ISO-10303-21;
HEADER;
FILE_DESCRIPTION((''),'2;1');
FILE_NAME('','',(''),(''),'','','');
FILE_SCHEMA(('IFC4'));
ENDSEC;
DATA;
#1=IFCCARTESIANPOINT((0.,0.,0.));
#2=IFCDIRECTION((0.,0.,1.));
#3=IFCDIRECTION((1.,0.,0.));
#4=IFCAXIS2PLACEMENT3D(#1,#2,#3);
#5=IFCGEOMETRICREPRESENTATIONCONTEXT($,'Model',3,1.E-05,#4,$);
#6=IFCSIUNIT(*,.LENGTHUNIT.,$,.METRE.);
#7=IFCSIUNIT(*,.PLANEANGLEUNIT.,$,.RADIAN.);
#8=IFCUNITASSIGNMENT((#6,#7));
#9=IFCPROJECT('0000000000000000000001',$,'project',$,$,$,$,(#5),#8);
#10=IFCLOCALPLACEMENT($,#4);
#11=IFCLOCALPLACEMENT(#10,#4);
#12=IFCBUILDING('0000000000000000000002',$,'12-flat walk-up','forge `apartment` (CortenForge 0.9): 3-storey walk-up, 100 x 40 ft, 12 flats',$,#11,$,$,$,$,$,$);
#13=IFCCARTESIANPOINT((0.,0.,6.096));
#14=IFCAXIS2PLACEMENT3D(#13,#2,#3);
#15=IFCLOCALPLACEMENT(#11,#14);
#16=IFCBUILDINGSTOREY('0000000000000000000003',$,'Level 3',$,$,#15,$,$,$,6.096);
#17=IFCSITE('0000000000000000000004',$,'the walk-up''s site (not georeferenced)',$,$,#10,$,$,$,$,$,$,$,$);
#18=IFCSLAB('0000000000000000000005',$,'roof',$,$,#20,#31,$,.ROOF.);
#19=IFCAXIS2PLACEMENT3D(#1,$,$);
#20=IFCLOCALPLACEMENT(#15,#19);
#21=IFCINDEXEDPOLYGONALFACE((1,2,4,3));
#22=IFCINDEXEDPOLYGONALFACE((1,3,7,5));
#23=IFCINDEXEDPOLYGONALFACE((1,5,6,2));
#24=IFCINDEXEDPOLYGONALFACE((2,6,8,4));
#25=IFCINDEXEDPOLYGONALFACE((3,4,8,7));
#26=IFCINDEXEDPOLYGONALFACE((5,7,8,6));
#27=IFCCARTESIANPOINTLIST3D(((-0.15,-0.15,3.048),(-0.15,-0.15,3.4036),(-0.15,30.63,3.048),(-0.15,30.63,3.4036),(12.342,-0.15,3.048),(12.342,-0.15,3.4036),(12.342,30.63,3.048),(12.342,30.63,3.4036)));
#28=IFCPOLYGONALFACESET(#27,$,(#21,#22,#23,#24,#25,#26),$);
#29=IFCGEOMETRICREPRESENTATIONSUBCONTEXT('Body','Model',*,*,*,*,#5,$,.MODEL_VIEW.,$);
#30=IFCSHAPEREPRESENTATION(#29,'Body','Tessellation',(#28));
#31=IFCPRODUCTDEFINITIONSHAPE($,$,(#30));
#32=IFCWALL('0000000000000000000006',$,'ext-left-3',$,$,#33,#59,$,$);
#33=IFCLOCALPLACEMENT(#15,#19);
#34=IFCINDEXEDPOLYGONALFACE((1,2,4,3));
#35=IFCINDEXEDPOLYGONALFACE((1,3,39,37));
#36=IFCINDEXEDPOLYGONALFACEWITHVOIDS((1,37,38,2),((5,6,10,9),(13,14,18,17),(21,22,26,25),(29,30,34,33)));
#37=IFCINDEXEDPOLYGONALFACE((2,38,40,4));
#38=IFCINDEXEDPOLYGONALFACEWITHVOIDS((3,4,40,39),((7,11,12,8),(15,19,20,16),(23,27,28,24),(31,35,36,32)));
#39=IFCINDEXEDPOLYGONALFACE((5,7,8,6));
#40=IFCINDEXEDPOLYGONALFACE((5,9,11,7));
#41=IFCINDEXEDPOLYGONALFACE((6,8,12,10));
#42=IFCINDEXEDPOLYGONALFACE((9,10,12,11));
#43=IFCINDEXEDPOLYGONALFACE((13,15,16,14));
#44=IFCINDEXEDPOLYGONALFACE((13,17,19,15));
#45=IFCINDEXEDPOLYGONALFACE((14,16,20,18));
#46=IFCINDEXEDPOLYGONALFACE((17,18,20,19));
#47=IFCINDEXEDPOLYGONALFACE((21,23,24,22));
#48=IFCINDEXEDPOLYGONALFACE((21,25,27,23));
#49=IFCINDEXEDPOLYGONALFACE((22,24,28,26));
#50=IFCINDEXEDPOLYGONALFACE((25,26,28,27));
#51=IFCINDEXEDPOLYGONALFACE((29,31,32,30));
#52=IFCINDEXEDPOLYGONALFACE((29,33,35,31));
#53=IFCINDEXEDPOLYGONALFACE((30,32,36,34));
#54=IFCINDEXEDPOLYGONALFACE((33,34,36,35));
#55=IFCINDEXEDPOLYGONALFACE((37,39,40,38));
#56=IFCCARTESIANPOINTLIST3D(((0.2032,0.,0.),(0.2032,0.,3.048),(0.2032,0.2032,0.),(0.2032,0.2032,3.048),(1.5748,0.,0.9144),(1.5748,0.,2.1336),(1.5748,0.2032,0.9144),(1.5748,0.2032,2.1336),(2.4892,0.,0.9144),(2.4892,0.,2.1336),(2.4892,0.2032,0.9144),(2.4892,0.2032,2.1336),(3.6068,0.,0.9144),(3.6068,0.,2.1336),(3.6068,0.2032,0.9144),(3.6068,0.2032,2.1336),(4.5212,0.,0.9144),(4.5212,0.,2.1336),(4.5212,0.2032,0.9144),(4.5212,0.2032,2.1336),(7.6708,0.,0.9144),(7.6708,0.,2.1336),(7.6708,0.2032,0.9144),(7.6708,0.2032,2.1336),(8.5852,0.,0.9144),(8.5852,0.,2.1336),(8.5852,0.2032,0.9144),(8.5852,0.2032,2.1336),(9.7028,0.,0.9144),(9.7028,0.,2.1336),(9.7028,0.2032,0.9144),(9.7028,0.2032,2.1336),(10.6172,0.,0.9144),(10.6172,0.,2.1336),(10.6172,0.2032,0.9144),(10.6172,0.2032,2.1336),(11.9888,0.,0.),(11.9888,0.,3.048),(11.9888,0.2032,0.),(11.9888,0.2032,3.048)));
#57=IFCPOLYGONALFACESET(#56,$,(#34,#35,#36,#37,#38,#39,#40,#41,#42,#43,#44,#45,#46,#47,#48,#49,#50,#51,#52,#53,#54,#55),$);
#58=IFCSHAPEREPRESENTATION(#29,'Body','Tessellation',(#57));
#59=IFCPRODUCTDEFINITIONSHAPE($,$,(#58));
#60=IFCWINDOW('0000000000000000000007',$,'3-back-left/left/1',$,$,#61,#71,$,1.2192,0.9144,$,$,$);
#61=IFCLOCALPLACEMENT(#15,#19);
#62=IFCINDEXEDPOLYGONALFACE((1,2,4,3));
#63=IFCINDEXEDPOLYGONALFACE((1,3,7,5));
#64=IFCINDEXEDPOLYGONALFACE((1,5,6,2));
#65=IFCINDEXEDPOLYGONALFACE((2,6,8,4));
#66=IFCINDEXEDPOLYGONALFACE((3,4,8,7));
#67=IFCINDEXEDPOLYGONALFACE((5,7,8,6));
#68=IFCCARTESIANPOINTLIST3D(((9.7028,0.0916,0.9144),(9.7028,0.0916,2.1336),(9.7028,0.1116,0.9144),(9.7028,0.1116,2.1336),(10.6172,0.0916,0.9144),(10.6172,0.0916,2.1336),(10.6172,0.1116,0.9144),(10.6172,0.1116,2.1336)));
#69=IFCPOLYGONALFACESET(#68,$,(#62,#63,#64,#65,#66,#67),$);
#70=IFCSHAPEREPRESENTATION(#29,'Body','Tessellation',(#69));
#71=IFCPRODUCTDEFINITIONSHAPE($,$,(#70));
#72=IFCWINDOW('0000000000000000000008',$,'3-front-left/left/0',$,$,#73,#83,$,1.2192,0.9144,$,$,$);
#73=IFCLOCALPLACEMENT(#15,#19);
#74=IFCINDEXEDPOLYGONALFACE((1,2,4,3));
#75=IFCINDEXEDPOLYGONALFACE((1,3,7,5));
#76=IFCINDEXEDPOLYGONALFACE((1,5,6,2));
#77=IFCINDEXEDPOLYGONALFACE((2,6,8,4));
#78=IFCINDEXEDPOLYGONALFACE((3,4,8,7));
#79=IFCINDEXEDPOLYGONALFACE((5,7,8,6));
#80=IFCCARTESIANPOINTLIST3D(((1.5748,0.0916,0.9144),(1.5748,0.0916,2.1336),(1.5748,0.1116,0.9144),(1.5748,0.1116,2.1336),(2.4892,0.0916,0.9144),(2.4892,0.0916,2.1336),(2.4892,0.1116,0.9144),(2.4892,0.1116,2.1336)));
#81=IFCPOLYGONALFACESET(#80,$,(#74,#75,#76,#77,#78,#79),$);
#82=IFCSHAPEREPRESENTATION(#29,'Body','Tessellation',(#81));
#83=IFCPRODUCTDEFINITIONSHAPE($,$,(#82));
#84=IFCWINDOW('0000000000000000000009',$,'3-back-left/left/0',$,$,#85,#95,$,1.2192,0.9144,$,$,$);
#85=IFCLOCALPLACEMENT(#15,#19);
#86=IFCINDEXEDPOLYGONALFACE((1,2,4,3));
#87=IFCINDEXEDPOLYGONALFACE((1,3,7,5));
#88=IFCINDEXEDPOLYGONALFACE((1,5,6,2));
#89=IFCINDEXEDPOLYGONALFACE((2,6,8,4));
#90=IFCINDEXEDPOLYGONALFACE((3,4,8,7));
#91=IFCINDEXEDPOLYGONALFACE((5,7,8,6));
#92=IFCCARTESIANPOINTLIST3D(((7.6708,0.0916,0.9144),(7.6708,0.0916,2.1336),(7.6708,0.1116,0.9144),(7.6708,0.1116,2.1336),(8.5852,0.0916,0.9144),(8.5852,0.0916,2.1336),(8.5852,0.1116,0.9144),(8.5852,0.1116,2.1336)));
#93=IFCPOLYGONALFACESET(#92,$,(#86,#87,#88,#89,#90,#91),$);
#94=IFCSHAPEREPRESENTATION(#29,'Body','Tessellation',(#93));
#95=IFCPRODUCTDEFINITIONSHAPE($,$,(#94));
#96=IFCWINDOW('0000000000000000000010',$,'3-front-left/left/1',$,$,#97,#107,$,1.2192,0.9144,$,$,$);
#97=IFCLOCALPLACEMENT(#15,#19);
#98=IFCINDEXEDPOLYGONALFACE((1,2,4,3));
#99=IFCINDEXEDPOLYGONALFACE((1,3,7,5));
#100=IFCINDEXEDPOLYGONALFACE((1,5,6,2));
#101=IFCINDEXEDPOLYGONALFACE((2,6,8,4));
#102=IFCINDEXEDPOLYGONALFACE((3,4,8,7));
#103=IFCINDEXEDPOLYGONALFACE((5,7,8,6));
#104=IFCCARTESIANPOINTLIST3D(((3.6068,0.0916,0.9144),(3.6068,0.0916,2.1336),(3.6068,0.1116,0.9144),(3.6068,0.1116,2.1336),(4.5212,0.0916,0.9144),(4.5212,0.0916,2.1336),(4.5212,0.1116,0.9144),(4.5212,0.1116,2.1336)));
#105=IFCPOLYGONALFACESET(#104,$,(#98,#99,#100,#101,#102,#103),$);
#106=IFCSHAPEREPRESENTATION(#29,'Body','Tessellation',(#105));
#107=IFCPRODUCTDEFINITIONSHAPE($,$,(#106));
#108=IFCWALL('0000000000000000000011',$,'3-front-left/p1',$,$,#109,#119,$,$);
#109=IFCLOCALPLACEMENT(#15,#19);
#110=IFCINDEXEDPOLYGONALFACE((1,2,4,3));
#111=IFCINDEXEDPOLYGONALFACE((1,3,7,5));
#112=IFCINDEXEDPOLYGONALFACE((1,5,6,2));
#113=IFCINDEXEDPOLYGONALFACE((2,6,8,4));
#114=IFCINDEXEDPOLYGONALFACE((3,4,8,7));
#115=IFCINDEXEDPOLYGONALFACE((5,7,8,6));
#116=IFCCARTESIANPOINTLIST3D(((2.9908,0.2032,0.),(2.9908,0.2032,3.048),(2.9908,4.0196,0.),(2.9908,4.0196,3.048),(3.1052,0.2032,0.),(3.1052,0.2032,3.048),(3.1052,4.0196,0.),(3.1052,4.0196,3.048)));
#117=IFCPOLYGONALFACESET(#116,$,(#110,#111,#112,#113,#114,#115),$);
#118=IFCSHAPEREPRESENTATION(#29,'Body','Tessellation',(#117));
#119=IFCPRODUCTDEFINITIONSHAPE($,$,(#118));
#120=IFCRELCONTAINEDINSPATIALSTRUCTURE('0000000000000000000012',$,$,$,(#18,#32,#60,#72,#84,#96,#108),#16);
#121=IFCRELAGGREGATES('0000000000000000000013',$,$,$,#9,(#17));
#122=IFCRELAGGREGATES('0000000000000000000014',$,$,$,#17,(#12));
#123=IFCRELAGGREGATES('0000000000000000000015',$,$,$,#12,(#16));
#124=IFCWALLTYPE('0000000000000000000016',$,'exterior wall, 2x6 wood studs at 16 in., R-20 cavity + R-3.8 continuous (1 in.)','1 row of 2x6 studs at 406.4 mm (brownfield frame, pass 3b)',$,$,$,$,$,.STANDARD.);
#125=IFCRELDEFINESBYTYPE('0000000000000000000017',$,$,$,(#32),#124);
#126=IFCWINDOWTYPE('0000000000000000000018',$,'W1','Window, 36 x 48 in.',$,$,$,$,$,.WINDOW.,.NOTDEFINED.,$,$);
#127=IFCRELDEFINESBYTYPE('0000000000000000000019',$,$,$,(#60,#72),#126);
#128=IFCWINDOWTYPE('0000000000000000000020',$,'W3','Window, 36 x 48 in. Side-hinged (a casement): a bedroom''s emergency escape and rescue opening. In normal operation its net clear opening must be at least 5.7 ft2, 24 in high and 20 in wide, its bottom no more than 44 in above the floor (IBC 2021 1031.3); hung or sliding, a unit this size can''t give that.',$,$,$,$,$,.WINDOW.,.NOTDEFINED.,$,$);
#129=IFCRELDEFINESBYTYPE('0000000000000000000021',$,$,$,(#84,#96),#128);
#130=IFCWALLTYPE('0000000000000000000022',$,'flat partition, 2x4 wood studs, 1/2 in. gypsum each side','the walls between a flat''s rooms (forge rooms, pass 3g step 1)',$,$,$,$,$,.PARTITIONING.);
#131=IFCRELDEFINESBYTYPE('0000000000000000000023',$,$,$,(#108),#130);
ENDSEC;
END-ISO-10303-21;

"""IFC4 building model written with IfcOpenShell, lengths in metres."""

from ifc_helpers import new_model, si_unit, frame, frame_2d, origin, origin_with_axes, place, context, subcontext, project, spatial, rectangle, extrude, type_object, element, fill, save


model = new_model("IFC4")

# Units and contexts
model_context = context("Model", 3, precision=1e-05, world=origin_with_axes())
body_context = subcontext(model_context, "Body", "Model", "MODEL_VIEW")
ifc_project = project(units=[si_unit("LENGTHUNIT", "METRE"), si_unit("PLANEANGLEUNIT", "RADIAN")], contexts=[model_context])

# Site, building, storey
site_placement = place(None, origin_with_axes())
site = spatial("IfcSite", under=ifc_project, at=site_placement, Name="the walk-up's site (not georeferenced)")
building_placement = place(site_placement, origin_with_axes())
building = spatial("IfcBuilding", under=site, at=building_placement, Name="12-flat walk-up", Description="forge `apartment` (CortenForge 0.9): 3-storey walk-up, 100 x 40 ft, 12 flats")
storey_placement = place(building_placement, frame((0.0, 0.0, 6.096), z_axis=(0.0, 0.0, 1.0), x_axis=(1.0, 0.0, 0.0)))
storey = spatial("IfcBuildingStorey", under=building, at=storey_placement, Name="Level 3", Elevation=6.096)

# Slab
slab_placement = place(storey_placement, frame((-0.15, -0.15, 3.048), z_axis=(0.0, 0.0, 1.0), x_axis=(1.0, 0.0, 0.0)))
element("IfcSlab", 1, at=slab_placement, inside=storey, Name="roof", PredefinedType="ROOF", context=body_context, shape_type="SweptSolid", body=[
    extrude(rectangle(XDim=12.492, YDim=30.78, at=frame_2d((6.246, 15.39))), origin(), (0.0, 0.0, 1.0), 0.3556),
])

# Wall, openings, windows
wall_type_1 = type_object("IfcWallType", Name="exterior wall, 2x6 wood studs at 16 in., R-20 cavity + R-3.8 continuous (1 in.)", Description="1 row of 2x6 studs at 406.4 mm (brownfield frame, pass 3b)", PredefinedType="STANDARD")
wall_1_placement = place(storey_placement, frame((0.2032, 0.0, 0.0), z_axis=(0.0, 0.0, 1.0), x_axis=(1.0, 0.0, 0.0)))
wall_1 = element("IfcWall", 2, at=wall_1_placement, inside=storey, type_object=wall_type_1, Name="ext-left-3", context=body_context, shape_type="SweptSolid", body=[
    extrude(rectangle(XDim=11.7856, YDim=0.2032, at=frame_2d((5.8928, 0.1016))), origin(), (0.0, 0.0, 1.0), 3.048),
])
opening_1_placement = place(wall_1_placement, frame((7.4676, 0.0, 0.9144), z_axis=(0.0, 0.0, 1.0), x_axis=(1.0, 0.0, 0.0)))
opening_1 = element("IfcOpeningElement", 3, at=opening_1_placement, cuts=wall_1, PredefinedType="OPENING", context=body_context, shape_type="SweptSolid", body=[
    extrude(rectangle(XDim=0.9144, YDim=0.2032, at=frame_2d((0.4572, 0.1016))), origin(), (0.0, 0.0, 1.0), 1.2192),
])
opening_2_placement = place(wall_1_placement, frame((9.4996, 0.0, 0.9144), z_axis=(0.0, 0.0, 1.0), x_axis=(1.0, 0.0, 0.0)))
opening_2 = element("IfcOpeningElement", 4, at=opening_2_placement, cuts=wall_1, PredefinedType="OPENING", context=body_context, shape_type="SweptSolid", body=[
    extrude(rectangle(XDim=0.9144, YDim=0.2032, at=frame_2d((0.4572, 0.1016))), origin(), (0.0, 0.0, 1.0), 1.2192),
])
opening_3_placement = place(wall_1_placement, frame((1.3716, 0.0, 0.9144), z_axis=(0.0, 0.0, 1.0), x_axis=(1.0, 0.0, 0.0)))
opening_3 = element("IfcOpeningElement", 5, at=opening_3_placement, cuts=wall_1, PredefinedType="OPENING", context=body_context, shape_type="SweptSolid", body=[
    extrude(rectangle(XDim=0.9144, YDim=0.2032, at=frame_2d((0.4572, 0.1016))), origin(), (0.0, 0.0, 1.0), 1.2192),
])
opening_4_placement = place(wall_1_placement, frame((3.4036, 0.0, 0.9144), z_axis=(0.0, 0.0, 1.0), x_axis=(1.0, 0.0, 0.0)))
opening_4 = element("IfcOpeningElement", 6, at=opening_4_placement, cuts=wall_1, PredefinedType="OPENING", context=body_context, shape_type="SweptSolid", body=[
    extrude(rectangle(XDim=0.9144, YDim=0.2032, at=frame_2d((0.4572, 0.1016))), origin(), (0.0, 0.0, 1.0), 1.2192),
])
window_type_1 = type_object("IfcWindowType", Name="W1", Description="Window, 36 x 48 in.", PartitioningType="NOTDEFINED", PredefinedType="WINDOW")
window_1_placement = place(opening_2_placement, frame((0.0, 0.0916, 0.0), z_axis=(0.0, 0.0, 1.0), x_axis=(1.0, 0.0, 0.0)))
window_1 = element("IfcWindow", 7, at=window_1_placement, inside=storey, type_object=window_type_1, Name="3-back-left/left/1", OverallHeight=1.2192, OverallWidth=0.9144, context=body_context, shape_type="SweptSolid", body=[
    extrude(rectangle(XDim=0.9144, YDim=0.02, at=frame_2d((0.4572, 0.01))), origin(), (0.0, 0.0, 1.0), 1.2192),
])
fill(opening_2, window_1)
window_2_placement = place(opening_3_placement, frame((0.0, 0.0916, 0.0), z_axis=(0.0, 0.0, 1.0), x_axis=(1.0, 0.0, 0.0)))
window_2 = element("IfcWindow", 8, at=window_2_placement, inside=storey, type_object=window_type_1, Name="3-front-left/left/0", OverallHeight=1.2192, OverallWidth=0.9144, context=body_context, shape_type="SweptSolid", body=[
    extrude(rectangle(XDim=0.9144, YDim=0.02, at=frame_2d((0.4572, 0.01))), origin(), (0.0, 0.0, 1.0), 1.2192),
])
fill(opening_3, window_2)
window_type_2 = type_object("IfcWindowType", Name="W3", Description="Window, 36 x 48 in. Side-hinged (a casement): a bedroom's emergency escape and rescue opening. In normal operation its net clear opening must be at least 5.7 ft2, 24 in high and 20 in wide, its bottom no more than 44 in above the floor (IBC 2021 1031.3); hung or sliding, a unit this size can't give that.", PartitioningType="NOTDEFINED", PredefinedType="WINDOW")
window_3_placement = place(opening_1_placement, frame((0.0, 0.0916, 0.0), z_axis=(0.0, 0.0, 1.0), x_axis=(1.0, 0.0, 0.0)))
window_3 = element("IfcWindow", 9, at=window_3_placement, inside=storey, type_object=window_type_2, Name="3-back-left/left/0", OverallHeight=1.2192, OverallWidth=0.9144, context=body_context, shape_type="SweptSolid", body=[
    extrude(rectangle(XDim=0.9144, YDim=0.02, at=frame_2d((0.4572, 0.01))), origin(), (0.0, 0.0, 1.0), 1.2192),
])
fill(opening_1, window_3)
window_4_placement = place(opening_4_placement, frame((0.0, 0.0916, 0.0), z_axis=(0.0, 0.0, 1.0), x_axis=(1.0, 0.0, 0.0)))
window_4 = element("IfcWindow", 10, at=window_4_placement, inside=storey, type_object=window_type_2, Name="3-front-left/left/1", OverallHeight=1.2192, OverallWidth=0.9144, context=body_context, shape_type="SweptSolid", body=[
    extrude(rectangle(XDim=0.9144, YDim=0.02, at=frame_2d((0.4572, 0.01))), origin(), (0.0, 0.0, 1.0), 1.2192),
])
fill(opening_4, window_4)

# Wall
wall_type_2 = type_object("IfcWallType", Name="flat partition, 2x4 wood studs, 1/2 in. gypsum each side", Description="the walls between a flat's rooms (forge rooms, pass 3g step 1)", PredefinedType="PARTITIONING")
wall_2_placement = place(storey_placement, frame((2.9909, 0.2032, 0.0), z_axis=(0.0, 0.0, 1.0), x_axis=(1.0, 0.0, 0.0)))
element("IfcWall", 11, at=wall_2_placement, inside=storey, type_object=wall_type_2, Name="3-front-left/p1", context=body_context, shape_type="SweptSolid", body=[
    extrude(rectangle(XDim=0.1143, YDim=3.8163, at=frame_2d((0.0572, 1.9082))), origin(), (0.0, 0.0, 1.0), 3.048),
])

save(model, "model.ifc")
